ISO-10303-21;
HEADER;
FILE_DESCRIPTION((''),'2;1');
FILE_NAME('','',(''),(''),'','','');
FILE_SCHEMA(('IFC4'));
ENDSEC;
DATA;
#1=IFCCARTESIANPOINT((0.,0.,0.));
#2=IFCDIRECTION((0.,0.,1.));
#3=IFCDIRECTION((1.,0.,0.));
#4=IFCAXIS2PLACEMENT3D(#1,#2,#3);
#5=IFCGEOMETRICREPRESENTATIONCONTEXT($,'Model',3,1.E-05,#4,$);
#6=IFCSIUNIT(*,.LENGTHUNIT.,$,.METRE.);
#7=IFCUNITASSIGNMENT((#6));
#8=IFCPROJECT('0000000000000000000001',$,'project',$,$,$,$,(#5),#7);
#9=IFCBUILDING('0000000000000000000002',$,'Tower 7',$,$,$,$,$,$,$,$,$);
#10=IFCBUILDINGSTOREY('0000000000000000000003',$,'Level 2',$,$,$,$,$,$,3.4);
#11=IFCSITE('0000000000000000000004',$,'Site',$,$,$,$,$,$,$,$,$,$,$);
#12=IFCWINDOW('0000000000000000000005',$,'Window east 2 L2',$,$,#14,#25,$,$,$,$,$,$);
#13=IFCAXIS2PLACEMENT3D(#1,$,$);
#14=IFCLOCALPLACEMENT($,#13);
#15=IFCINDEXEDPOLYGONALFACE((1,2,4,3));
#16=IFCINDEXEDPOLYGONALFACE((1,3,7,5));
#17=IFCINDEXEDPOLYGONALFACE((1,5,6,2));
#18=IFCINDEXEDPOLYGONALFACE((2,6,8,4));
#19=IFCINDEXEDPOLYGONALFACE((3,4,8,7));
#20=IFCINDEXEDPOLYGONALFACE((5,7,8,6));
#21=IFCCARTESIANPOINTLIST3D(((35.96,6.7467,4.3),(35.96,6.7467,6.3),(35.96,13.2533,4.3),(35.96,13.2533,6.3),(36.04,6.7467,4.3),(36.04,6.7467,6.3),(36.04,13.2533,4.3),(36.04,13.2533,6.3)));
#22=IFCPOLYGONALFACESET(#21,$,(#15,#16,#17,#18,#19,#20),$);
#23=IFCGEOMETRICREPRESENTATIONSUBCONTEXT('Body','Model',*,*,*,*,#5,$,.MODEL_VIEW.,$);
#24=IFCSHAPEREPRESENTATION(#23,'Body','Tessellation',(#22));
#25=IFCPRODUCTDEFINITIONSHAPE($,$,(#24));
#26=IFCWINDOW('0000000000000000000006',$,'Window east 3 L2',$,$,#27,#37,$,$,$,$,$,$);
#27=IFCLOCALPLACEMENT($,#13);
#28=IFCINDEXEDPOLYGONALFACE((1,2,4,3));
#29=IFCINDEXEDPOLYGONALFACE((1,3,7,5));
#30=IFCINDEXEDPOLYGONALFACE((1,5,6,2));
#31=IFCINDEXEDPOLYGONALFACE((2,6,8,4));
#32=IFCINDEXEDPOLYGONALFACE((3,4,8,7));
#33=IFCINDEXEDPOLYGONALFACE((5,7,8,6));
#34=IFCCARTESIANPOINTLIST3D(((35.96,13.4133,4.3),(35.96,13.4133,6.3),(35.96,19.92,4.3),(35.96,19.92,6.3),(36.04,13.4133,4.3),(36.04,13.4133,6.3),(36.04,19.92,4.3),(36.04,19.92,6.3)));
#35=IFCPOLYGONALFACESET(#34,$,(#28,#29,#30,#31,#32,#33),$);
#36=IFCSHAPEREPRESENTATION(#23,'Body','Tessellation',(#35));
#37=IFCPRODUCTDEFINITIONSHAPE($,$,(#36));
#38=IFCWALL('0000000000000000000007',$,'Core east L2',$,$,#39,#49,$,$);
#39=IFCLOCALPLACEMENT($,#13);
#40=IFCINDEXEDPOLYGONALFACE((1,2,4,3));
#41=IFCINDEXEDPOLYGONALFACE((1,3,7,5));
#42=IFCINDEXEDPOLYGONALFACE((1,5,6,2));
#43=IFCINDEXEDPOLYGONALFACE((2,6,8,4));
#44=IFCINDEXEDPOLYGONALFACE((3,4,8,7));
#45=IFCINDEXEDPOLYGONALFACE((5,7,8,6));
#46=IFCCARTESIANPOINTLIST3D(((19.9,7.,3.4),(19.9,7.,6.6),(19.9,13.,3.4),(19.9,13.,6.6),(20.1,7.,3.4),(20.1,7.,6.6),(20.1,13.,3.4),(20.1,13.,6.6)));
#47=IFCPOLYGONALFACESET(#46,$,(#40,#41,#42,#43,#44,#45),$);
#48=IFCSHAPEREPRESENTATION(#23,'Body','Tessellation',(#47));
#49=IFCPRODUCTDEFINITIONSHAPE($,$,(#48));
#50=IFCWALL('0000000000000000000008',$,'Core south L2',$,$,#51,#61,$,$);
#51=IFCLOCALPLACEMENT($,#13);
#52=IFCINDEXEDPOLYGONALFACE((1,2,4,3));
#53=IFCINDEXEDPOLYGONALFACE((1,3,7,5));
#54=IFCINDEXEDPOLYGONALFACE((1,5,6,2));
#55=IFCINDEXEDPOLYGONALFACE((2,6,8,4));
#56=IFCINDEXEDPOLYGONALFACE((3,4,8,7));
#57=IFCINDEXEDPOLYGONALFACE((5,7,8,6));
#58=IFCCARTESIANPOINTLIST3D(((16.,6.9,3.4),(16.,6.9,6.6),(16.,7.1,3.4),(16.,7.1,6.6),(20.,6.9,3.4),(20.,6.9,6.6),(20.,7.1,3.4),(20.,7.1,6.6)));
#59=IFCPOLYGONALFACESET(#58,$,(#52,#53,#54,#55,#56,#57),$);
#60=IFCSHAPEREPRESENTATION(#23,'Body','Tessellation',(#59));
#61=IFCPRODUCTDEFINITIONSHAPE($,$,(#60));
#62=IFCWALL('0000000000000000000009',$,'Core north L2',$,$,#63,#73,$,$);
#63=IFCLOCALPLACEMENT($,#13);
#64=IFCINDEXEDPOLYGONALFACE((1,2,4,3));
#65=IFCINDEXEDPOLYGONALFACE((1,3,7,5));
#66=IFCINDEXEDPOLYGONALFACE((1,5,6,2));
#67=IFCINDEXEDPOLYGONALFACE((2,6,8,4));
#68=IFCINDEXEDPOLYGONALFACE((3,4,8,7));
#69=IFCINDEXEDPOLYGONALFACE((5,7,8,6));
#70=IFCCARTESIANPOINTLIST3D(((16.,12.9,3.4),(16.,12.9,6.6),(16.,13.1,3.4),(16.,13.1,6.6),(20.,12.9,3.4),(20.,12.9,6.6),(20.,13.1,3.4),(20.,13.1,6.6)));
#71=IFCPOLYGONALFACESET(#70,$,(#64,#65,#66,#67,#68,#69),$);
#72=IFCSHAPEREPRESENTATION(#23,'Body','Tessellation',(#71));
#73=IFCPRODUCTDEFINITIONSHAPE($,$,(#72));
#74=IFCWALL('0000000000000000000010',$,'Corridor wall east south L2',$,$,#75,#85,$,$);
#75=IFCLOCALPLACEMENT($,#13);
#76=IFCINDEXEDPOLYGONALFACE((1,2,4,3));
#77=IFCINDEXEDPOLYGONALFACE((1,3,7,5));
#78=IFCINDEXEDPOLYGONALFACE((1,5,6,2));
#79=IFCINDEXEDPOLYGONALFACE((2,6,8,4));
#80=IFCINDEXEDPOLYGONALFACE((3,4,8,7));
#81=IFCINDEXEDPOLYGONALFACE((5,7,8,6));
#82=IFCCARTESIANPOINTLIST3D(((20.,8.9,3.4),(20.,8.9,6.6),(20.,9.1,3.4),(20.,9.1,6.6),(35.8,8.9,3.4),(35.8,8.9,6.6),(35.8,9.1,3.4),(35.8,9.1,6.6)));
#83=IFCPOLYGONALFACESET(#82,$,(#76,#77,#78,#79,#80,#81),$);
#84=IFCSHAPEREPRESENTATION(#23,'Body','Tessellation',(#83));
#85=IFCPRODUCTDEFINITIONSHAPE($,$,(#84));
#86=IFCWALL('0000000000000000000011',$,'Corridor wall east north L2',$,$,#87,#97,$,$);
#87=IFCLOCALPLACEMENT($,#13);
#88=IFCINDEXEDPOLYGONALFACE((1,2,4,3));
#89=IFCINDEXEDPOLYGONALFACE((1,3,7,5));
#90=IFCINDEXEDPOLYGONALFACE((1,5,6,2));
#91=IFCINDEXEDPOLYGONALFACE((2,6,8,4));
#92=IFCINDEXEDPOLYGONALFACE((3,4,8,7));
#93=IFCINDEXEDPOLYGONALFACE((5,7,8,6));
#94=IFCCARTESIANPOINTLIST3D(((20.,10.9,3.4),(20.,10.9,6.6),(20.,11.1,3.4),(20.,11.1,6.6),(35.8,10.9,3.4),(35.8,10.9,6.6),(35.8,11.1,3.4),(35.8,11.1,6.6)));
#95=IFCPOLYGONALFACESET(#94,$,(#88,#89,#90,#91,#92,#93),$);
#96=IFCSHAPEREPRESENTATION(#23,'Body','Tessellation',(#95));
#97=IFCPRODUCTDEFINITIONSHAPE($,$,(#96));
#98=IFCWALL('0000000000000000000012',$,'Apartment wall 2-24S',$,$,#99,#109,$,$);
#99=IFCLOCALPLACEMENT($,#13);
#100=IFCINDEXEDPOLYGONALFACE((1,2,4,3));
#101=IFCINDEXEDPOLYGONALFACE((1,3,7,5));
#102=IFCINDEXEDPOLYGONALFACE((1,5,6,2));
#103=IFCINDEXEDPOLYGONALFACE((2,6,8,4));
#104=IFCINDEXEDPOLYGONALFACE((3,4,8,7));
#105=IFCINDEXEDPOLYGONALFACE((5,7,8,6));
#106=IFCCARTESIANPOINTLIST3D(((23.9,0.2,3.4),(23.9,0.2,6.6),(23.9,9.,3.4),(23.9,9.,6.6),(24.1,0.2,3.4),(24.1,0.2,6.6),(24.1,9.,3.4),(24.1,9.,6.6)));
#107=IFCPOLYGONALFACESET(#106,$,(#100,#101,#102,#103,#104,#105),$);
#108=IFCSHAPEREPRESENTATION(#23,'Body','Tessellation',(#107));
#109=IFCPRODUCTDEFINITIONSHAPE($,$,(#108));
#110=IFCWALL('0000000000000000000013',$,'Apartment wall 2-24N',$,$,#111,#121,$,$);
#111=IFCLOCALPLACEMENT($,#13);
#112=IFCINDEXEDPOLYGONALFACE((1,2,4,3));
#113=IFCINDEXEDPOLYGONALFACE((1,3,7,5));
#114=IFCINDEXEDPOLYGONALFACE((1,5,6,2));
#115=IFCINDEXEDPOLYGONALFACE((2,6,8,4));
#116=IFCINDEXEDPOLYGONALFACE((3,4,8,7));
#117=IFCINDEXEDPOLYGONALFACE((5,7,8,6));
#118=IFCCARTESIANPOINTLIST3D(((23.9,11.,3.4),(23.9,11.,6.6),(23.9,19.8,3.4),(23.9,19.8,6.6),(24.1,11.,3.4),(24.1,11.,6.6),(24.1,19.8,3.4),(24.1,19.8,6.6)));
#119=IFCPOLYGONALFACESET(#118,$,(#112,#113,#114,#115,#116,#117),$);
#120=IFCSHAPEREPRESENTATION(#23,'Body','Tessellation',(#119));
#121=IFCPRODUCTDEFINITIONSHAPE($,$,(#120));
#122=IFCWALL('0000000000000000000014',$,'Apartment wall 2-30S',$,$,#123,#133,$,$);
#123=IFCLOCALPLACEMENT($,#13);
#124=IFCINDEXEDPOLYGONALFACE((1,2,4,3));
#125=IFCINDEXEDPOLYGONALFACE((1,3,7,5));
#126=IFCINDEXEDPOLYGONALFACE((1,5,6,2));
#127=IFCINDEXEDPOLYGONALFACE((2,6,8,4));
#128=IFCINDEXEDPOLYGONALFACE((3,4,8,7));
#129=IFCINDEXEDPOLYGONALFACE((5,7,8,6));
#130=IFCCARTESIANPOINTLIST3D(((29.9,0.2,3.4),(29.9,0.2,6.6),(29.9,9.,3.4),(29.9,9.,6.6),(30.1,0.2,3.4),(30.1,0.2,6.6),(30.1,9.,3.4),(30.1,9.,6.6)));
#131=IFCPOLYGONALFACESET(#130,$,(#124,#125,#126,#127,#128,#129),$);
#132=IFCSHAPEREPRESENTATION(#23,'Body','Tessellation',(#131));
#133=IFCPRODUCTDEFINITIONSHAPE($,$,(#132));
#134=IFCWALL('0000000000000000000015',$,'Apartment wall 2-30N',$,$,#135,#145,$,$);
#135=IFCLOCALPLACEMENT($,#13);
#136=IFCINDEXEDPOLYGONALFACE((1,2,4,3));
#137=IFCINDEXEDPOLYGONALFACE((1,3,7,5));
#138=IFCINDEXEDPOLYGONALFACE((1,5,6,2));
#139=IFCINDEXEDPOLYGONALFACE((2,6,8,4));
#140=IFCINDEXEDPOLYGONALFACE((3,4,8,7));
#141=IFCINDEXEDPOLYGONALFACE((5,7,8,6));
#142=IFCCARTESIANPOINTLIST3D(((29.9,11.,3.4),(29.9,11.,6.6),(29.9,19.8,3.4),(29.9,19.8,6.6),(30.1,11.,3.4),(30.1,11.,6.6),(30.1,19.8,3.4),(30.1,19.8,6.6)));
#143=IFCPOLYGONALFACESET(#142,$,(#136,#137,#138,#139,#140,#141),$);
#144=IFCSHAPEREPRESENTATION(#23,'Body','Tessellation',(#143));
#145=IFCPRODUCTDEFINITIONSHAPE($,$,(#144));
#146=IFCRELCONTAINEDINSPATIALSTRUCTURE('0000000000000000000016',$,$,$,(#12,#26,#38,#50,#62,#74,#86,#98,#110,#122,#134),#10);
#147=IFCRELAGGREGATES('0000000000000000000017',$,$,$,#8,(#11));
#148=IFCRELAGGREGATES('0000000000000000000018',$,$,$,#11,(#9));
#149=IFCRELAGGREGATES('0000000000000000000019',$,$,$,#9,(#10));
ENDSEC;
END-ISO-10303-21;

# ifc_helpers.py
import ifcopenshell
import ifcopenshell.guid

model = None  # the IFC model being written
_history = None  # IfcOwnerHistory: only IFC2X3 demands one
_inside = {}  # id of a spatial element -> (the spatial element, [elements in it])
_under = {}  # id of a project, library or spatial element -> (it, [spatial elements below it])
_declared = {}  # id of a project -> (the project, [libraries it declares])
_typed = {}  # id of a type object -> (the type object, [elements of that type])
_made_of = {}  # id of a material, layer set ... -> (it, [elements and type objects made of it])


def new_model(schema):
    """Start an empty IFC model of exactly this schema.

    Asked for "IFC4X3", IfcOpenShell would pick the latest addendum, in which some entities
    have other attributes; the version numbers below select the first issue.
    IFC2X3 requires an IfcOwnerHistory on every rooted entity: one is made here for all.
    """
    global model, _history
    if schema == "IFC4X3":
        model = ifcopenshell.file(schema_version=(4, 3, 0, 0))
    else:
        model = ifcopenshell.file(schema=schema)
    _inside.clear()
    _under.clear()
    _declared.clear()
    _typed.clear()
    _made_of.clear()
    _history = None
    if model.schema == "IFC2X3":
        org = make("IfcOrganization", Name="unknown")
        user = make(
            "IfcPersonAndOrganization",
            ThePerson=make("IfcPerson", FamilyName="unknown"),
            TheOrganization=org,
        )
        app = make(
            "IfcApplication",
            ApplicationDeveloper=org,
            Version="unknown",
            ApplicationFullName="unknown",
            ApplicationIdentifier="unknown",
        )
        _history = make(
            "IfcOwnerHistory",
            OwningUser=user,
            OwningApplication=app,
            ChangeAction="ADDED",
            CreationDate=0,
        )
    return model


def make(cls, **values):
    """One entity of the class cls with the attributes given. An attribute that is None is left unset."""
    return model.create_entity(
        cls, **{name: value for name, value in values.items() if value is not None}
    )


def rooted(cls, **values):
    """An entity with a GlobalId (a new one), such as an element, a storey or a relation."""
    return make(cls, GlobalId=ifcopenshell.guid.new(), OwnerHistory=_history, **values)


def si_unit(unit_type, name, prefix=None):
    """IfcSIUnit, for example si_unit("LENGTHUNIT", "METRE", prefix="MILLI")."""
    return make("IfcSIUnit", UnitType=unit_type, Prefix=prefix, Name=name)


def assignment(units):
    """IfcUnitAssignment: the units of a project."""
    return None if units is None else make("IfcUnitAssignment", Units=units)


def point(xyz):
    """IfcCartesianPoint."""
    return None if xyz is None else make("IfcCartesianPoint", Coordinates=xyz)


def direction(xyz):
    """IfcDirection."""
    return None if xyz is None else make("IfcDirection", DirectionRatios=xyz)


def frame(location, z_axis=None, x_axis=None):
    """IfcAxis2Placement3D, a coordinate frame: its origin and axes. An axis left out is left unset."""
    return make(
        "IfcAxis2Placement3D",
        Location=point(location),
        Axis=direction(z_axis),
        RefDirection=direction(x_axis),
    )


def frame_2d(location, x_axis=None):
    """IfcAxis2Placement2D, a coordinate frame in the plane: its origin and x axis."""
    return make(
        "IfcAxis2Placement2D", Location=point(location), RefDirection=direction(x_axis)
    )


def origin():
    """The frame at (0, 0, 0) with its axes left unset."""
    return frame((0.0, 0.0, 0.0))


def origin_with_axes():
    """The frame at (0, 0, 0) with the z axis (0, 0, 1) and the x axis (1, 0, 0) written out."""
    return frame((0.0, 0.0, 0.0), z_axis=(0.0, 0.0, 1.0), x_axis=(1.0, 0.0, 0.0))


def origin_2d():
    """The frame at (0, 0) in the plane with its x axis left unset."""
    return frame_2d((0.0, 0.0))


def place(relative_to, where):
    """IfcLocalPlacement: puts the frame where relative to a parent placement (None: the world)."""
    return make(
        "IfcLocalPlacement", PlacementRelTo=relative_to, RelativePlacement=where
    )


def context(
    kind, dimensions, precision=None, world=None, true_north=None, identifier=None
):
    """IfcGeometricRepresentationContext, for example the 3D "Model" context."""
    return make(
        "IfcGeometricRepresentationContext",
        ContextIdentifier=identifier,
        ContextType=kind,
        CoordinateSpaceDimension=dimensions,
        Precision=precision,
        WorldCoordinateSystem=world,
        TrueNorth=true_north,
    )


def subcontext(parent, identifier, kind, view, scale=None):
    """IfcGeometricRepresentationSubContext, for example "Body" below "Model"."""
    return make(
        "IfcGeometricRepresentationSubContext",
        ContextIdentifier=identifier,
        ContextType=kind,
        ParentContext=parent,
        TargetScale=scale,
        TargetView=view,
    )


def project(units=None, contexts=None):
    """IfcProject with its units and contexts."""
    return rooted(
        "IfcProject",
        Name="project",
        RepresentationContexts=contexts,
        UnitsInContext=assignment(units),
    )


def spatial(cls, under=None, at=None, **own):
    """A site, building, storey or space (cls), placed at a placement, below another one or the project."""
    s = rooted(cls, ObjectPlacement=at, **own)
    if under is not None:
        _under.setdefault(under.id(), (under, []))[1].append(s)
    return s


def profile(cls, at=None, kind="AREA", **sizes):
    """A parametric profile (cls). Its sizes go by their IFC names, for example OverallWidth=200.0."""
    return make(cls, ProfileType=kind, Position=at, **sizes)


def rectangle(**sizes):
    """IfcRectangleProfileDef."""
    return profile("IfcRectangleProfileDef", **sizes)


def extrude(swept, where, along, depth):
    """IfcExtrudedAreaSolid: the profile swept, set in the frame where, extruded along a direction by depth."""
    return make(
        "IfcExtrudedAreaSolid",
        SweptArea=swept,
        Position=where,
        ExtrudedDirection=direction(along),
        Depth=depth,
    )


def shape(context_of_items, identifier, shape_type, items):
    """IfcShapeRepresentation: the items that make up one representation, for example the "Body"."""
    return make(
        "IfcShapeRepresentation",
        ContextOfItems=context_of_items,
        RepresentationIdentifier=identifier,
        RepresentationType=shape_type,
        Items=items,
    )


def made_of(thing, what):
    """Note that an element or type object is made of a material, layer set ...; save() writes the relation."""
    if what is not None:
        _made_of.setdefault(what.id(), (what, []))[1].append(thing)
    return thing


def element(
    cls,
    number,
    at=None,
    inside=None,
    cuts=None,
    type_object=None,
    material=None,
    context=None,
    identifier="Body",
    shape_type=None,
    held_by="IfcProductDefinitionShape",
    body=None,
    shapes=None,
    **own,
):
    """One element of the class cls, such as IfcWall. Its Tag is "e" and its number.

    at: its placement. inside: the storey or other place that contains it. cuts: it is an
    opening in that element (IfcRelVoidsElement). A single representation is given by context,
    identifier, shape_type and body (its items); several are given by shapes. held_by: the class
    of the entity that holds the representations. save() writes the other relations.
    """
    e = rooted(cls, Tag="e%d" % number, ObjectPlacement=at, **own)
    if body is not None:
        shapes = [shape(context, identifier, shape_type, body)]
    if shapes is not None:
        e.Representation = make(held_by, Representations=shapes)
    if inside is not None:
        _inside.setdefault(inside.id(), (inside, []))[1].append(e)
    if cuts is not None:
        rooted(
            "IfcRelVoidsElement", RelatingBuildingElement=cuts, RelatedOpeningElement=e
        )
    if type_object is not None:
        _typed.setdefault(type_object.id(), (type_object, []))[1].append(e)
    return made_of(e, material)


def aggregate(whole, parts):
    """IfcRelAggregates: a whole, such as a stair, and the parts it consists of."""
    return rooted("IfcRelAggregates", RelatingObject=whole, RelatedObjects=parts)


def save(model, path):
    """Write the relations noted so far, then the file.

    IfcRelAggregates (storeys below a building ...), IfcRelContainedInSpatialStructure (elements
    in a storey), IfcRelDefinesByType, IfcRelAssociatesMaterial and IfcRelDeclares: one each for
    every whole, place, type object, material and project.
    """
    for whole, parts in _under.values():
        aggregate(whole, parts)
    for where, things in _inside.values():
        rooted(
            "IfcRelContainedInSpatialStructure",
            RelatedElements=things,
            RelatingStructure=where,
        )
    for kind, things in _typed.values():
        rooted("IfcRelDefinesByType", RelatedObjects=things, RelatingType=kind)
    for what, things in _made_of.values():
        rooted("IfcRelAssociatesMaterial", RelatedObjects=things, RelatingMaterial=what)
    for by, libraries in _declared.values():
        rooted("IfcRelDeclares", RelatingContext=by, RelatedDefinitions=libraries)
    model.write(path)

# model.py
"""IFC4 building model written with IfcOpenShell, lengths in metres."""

from ifc_helpers import new_model, si_unit, frame, origin, origin_with_axes, origin_2d, place, context, subcontext, project, spatial, rectangle, extrude, element, save


model = new_model("IFC4")

# Units and contexts
model_context = context("Model", 3, precision=1e-05, world=origin_with_axes())
body_context = subcontext(model_context, "Body", "Model", "MODEL_VIEW")
ifc_project = project(units=[si_unit("LENGTHUNIT", "METRE")], contexts=[model_context])

# Site, building, storey
site = spatial("IfcSite", under=ifc_project, Name="Site")
building = spatial("IfcBuilding", under=site, Name="Tower 7")
storey = spatial("IfcBuildingStorey", under=building, Name="Level 2", Elevation=3.4)

# Windows
for number, where, z_axis, x_axis, name in (
    (1, (36.0, 10.0, 4.3), (0.0, 0.0, 1.0), (1.0, 0.0, 0.0), "Window east 2 L2"),
):
    element("IfcWindow", number, at=place(None, frame(where, z_axis=z_axis, x_axis=x_axis)), inside=storey, Name=name, context=body_context, shape_type="SweptSolid", body=[
        extrude(rectangle(XDim=0.08, YDim=6.5067, at=origin_2d()), origin(), (0.0, 0.0, 1.0), 2.0),
    ])
window_placement = place(None, frame((36.0, 16.6667, 4.3), z_axis=(0.0, 0.0, 1.0), x_axis=(1.0, 0.0, 0.0)))
element("IfcWindow", 2, at=window_placement, inside=storey, Name="Window east 3 L2", context=body_context, shape_type="SweptSolid", body=[
    extrude(rectangle(XDim=0.08, YDim=6.5067, at=origin_2d()), origin(), (0.0, 0.0, 1.0), 2.0),
])

# Walls
wall_1_placement = place(None, frame((20.0, 10.0, 3.4), z_axis=(0.0, 0.0, 1.0), x_axis=(1.0, 0.0, 0.0)))
element("IfcWall", 3, at=wall_1_placement, inside=storey, Name="Core east L2", context=body_context, shape_type="SweptSolid", body=[
    extrude(rectangle(XDim=0.2, YDim=6.0, at=origin_2d()), origin(), (0.0, 0.0, 1.0), 3.2),
])
for number, where, z_axis, x_axis, name in (
    (4, (18.0, 7.0, 3.4), (0.0, 0.0, 1.0), (1.0, 0.0, 0.0), "Core south L2"),
    (5, (18.0, 13.0, 3.4), (0.0, 0.0, 1.0), (1.0, 0.0, 0.0), "Core north L2"),
):
    element("IfcWall", number, at=place(None, frame(where, z_axis=z_axis, x_axis=x_axis)), inside=storey, Name=name, context=body_context, shape_type="SweptSolid", body=[
        extrude(rectangle(XDim=4.0, YDim=0.2, at=origin_2d()), origin(), (0.0, 0.0, 1.0), 3.2),
    ])
for number, where, z_axis, x_axis, name in (
    (6, (27.9, 9.0, 3.4), (0.0, 0.0, 1.0), (1.0, 0.0, 0.0), "Corridor wall east south L2"),
    (7, (27.9, 11.0, 3.4), (0.0, 0.0, 1.0), (1.0, 0.0, 0.0), "Corridor wall east north L2"),
):
    element("IfcWall", number, at=place(None, frame(where, z_axis=z_axis, x_axis=x_axis)), inside=storey, Name=name, context=body_context, shape_type="SweptSolid", body=[
        extrude(rectangle(XDim=15.8, YDim=0.2, at=origin_2d()), origin(), (0.0, 0.0, 1.0), 3.2),
    ])
for number, where, z_axis, x_axis, name in (
    (8, (24.0, 4.6, 3.4), (0.0, 0.0, 1.0), (1.0, 0.0, 0.0), "Apartment wall 2-24S"),
    (9, (24.0, 15.4, 3.4), (0.0, 0.0, 1.0), (1.0, 0.0, 0.0), "Apartment wall 2-24N"),
    (10, (30.0, 4.6, 3.4), (0.0, 0.0, 1.0), (1.0, 0.0, 0.0), "Apartment wall 2-30S"),
    (11, (30.0, 15.4, 3.4), (0.0, 0.0, 1.0), (1.0, 0.0, 0.0), "Apartment wall 2-30N"),
):
    element("IfcWall", number, at=place(None, frame(where, z_axis=z_axis, x_axis=x_axis)), inside=storey, Name=name, context=body_context, shape_type="SweptSolid", body=[
        extrude(rectangle(XDim=0.2, YDim=8.8, at=origin_2d()), origin(), (0.0, 0.0, 1.0), 3.2),
    ])

save(model, "model.ifc")
